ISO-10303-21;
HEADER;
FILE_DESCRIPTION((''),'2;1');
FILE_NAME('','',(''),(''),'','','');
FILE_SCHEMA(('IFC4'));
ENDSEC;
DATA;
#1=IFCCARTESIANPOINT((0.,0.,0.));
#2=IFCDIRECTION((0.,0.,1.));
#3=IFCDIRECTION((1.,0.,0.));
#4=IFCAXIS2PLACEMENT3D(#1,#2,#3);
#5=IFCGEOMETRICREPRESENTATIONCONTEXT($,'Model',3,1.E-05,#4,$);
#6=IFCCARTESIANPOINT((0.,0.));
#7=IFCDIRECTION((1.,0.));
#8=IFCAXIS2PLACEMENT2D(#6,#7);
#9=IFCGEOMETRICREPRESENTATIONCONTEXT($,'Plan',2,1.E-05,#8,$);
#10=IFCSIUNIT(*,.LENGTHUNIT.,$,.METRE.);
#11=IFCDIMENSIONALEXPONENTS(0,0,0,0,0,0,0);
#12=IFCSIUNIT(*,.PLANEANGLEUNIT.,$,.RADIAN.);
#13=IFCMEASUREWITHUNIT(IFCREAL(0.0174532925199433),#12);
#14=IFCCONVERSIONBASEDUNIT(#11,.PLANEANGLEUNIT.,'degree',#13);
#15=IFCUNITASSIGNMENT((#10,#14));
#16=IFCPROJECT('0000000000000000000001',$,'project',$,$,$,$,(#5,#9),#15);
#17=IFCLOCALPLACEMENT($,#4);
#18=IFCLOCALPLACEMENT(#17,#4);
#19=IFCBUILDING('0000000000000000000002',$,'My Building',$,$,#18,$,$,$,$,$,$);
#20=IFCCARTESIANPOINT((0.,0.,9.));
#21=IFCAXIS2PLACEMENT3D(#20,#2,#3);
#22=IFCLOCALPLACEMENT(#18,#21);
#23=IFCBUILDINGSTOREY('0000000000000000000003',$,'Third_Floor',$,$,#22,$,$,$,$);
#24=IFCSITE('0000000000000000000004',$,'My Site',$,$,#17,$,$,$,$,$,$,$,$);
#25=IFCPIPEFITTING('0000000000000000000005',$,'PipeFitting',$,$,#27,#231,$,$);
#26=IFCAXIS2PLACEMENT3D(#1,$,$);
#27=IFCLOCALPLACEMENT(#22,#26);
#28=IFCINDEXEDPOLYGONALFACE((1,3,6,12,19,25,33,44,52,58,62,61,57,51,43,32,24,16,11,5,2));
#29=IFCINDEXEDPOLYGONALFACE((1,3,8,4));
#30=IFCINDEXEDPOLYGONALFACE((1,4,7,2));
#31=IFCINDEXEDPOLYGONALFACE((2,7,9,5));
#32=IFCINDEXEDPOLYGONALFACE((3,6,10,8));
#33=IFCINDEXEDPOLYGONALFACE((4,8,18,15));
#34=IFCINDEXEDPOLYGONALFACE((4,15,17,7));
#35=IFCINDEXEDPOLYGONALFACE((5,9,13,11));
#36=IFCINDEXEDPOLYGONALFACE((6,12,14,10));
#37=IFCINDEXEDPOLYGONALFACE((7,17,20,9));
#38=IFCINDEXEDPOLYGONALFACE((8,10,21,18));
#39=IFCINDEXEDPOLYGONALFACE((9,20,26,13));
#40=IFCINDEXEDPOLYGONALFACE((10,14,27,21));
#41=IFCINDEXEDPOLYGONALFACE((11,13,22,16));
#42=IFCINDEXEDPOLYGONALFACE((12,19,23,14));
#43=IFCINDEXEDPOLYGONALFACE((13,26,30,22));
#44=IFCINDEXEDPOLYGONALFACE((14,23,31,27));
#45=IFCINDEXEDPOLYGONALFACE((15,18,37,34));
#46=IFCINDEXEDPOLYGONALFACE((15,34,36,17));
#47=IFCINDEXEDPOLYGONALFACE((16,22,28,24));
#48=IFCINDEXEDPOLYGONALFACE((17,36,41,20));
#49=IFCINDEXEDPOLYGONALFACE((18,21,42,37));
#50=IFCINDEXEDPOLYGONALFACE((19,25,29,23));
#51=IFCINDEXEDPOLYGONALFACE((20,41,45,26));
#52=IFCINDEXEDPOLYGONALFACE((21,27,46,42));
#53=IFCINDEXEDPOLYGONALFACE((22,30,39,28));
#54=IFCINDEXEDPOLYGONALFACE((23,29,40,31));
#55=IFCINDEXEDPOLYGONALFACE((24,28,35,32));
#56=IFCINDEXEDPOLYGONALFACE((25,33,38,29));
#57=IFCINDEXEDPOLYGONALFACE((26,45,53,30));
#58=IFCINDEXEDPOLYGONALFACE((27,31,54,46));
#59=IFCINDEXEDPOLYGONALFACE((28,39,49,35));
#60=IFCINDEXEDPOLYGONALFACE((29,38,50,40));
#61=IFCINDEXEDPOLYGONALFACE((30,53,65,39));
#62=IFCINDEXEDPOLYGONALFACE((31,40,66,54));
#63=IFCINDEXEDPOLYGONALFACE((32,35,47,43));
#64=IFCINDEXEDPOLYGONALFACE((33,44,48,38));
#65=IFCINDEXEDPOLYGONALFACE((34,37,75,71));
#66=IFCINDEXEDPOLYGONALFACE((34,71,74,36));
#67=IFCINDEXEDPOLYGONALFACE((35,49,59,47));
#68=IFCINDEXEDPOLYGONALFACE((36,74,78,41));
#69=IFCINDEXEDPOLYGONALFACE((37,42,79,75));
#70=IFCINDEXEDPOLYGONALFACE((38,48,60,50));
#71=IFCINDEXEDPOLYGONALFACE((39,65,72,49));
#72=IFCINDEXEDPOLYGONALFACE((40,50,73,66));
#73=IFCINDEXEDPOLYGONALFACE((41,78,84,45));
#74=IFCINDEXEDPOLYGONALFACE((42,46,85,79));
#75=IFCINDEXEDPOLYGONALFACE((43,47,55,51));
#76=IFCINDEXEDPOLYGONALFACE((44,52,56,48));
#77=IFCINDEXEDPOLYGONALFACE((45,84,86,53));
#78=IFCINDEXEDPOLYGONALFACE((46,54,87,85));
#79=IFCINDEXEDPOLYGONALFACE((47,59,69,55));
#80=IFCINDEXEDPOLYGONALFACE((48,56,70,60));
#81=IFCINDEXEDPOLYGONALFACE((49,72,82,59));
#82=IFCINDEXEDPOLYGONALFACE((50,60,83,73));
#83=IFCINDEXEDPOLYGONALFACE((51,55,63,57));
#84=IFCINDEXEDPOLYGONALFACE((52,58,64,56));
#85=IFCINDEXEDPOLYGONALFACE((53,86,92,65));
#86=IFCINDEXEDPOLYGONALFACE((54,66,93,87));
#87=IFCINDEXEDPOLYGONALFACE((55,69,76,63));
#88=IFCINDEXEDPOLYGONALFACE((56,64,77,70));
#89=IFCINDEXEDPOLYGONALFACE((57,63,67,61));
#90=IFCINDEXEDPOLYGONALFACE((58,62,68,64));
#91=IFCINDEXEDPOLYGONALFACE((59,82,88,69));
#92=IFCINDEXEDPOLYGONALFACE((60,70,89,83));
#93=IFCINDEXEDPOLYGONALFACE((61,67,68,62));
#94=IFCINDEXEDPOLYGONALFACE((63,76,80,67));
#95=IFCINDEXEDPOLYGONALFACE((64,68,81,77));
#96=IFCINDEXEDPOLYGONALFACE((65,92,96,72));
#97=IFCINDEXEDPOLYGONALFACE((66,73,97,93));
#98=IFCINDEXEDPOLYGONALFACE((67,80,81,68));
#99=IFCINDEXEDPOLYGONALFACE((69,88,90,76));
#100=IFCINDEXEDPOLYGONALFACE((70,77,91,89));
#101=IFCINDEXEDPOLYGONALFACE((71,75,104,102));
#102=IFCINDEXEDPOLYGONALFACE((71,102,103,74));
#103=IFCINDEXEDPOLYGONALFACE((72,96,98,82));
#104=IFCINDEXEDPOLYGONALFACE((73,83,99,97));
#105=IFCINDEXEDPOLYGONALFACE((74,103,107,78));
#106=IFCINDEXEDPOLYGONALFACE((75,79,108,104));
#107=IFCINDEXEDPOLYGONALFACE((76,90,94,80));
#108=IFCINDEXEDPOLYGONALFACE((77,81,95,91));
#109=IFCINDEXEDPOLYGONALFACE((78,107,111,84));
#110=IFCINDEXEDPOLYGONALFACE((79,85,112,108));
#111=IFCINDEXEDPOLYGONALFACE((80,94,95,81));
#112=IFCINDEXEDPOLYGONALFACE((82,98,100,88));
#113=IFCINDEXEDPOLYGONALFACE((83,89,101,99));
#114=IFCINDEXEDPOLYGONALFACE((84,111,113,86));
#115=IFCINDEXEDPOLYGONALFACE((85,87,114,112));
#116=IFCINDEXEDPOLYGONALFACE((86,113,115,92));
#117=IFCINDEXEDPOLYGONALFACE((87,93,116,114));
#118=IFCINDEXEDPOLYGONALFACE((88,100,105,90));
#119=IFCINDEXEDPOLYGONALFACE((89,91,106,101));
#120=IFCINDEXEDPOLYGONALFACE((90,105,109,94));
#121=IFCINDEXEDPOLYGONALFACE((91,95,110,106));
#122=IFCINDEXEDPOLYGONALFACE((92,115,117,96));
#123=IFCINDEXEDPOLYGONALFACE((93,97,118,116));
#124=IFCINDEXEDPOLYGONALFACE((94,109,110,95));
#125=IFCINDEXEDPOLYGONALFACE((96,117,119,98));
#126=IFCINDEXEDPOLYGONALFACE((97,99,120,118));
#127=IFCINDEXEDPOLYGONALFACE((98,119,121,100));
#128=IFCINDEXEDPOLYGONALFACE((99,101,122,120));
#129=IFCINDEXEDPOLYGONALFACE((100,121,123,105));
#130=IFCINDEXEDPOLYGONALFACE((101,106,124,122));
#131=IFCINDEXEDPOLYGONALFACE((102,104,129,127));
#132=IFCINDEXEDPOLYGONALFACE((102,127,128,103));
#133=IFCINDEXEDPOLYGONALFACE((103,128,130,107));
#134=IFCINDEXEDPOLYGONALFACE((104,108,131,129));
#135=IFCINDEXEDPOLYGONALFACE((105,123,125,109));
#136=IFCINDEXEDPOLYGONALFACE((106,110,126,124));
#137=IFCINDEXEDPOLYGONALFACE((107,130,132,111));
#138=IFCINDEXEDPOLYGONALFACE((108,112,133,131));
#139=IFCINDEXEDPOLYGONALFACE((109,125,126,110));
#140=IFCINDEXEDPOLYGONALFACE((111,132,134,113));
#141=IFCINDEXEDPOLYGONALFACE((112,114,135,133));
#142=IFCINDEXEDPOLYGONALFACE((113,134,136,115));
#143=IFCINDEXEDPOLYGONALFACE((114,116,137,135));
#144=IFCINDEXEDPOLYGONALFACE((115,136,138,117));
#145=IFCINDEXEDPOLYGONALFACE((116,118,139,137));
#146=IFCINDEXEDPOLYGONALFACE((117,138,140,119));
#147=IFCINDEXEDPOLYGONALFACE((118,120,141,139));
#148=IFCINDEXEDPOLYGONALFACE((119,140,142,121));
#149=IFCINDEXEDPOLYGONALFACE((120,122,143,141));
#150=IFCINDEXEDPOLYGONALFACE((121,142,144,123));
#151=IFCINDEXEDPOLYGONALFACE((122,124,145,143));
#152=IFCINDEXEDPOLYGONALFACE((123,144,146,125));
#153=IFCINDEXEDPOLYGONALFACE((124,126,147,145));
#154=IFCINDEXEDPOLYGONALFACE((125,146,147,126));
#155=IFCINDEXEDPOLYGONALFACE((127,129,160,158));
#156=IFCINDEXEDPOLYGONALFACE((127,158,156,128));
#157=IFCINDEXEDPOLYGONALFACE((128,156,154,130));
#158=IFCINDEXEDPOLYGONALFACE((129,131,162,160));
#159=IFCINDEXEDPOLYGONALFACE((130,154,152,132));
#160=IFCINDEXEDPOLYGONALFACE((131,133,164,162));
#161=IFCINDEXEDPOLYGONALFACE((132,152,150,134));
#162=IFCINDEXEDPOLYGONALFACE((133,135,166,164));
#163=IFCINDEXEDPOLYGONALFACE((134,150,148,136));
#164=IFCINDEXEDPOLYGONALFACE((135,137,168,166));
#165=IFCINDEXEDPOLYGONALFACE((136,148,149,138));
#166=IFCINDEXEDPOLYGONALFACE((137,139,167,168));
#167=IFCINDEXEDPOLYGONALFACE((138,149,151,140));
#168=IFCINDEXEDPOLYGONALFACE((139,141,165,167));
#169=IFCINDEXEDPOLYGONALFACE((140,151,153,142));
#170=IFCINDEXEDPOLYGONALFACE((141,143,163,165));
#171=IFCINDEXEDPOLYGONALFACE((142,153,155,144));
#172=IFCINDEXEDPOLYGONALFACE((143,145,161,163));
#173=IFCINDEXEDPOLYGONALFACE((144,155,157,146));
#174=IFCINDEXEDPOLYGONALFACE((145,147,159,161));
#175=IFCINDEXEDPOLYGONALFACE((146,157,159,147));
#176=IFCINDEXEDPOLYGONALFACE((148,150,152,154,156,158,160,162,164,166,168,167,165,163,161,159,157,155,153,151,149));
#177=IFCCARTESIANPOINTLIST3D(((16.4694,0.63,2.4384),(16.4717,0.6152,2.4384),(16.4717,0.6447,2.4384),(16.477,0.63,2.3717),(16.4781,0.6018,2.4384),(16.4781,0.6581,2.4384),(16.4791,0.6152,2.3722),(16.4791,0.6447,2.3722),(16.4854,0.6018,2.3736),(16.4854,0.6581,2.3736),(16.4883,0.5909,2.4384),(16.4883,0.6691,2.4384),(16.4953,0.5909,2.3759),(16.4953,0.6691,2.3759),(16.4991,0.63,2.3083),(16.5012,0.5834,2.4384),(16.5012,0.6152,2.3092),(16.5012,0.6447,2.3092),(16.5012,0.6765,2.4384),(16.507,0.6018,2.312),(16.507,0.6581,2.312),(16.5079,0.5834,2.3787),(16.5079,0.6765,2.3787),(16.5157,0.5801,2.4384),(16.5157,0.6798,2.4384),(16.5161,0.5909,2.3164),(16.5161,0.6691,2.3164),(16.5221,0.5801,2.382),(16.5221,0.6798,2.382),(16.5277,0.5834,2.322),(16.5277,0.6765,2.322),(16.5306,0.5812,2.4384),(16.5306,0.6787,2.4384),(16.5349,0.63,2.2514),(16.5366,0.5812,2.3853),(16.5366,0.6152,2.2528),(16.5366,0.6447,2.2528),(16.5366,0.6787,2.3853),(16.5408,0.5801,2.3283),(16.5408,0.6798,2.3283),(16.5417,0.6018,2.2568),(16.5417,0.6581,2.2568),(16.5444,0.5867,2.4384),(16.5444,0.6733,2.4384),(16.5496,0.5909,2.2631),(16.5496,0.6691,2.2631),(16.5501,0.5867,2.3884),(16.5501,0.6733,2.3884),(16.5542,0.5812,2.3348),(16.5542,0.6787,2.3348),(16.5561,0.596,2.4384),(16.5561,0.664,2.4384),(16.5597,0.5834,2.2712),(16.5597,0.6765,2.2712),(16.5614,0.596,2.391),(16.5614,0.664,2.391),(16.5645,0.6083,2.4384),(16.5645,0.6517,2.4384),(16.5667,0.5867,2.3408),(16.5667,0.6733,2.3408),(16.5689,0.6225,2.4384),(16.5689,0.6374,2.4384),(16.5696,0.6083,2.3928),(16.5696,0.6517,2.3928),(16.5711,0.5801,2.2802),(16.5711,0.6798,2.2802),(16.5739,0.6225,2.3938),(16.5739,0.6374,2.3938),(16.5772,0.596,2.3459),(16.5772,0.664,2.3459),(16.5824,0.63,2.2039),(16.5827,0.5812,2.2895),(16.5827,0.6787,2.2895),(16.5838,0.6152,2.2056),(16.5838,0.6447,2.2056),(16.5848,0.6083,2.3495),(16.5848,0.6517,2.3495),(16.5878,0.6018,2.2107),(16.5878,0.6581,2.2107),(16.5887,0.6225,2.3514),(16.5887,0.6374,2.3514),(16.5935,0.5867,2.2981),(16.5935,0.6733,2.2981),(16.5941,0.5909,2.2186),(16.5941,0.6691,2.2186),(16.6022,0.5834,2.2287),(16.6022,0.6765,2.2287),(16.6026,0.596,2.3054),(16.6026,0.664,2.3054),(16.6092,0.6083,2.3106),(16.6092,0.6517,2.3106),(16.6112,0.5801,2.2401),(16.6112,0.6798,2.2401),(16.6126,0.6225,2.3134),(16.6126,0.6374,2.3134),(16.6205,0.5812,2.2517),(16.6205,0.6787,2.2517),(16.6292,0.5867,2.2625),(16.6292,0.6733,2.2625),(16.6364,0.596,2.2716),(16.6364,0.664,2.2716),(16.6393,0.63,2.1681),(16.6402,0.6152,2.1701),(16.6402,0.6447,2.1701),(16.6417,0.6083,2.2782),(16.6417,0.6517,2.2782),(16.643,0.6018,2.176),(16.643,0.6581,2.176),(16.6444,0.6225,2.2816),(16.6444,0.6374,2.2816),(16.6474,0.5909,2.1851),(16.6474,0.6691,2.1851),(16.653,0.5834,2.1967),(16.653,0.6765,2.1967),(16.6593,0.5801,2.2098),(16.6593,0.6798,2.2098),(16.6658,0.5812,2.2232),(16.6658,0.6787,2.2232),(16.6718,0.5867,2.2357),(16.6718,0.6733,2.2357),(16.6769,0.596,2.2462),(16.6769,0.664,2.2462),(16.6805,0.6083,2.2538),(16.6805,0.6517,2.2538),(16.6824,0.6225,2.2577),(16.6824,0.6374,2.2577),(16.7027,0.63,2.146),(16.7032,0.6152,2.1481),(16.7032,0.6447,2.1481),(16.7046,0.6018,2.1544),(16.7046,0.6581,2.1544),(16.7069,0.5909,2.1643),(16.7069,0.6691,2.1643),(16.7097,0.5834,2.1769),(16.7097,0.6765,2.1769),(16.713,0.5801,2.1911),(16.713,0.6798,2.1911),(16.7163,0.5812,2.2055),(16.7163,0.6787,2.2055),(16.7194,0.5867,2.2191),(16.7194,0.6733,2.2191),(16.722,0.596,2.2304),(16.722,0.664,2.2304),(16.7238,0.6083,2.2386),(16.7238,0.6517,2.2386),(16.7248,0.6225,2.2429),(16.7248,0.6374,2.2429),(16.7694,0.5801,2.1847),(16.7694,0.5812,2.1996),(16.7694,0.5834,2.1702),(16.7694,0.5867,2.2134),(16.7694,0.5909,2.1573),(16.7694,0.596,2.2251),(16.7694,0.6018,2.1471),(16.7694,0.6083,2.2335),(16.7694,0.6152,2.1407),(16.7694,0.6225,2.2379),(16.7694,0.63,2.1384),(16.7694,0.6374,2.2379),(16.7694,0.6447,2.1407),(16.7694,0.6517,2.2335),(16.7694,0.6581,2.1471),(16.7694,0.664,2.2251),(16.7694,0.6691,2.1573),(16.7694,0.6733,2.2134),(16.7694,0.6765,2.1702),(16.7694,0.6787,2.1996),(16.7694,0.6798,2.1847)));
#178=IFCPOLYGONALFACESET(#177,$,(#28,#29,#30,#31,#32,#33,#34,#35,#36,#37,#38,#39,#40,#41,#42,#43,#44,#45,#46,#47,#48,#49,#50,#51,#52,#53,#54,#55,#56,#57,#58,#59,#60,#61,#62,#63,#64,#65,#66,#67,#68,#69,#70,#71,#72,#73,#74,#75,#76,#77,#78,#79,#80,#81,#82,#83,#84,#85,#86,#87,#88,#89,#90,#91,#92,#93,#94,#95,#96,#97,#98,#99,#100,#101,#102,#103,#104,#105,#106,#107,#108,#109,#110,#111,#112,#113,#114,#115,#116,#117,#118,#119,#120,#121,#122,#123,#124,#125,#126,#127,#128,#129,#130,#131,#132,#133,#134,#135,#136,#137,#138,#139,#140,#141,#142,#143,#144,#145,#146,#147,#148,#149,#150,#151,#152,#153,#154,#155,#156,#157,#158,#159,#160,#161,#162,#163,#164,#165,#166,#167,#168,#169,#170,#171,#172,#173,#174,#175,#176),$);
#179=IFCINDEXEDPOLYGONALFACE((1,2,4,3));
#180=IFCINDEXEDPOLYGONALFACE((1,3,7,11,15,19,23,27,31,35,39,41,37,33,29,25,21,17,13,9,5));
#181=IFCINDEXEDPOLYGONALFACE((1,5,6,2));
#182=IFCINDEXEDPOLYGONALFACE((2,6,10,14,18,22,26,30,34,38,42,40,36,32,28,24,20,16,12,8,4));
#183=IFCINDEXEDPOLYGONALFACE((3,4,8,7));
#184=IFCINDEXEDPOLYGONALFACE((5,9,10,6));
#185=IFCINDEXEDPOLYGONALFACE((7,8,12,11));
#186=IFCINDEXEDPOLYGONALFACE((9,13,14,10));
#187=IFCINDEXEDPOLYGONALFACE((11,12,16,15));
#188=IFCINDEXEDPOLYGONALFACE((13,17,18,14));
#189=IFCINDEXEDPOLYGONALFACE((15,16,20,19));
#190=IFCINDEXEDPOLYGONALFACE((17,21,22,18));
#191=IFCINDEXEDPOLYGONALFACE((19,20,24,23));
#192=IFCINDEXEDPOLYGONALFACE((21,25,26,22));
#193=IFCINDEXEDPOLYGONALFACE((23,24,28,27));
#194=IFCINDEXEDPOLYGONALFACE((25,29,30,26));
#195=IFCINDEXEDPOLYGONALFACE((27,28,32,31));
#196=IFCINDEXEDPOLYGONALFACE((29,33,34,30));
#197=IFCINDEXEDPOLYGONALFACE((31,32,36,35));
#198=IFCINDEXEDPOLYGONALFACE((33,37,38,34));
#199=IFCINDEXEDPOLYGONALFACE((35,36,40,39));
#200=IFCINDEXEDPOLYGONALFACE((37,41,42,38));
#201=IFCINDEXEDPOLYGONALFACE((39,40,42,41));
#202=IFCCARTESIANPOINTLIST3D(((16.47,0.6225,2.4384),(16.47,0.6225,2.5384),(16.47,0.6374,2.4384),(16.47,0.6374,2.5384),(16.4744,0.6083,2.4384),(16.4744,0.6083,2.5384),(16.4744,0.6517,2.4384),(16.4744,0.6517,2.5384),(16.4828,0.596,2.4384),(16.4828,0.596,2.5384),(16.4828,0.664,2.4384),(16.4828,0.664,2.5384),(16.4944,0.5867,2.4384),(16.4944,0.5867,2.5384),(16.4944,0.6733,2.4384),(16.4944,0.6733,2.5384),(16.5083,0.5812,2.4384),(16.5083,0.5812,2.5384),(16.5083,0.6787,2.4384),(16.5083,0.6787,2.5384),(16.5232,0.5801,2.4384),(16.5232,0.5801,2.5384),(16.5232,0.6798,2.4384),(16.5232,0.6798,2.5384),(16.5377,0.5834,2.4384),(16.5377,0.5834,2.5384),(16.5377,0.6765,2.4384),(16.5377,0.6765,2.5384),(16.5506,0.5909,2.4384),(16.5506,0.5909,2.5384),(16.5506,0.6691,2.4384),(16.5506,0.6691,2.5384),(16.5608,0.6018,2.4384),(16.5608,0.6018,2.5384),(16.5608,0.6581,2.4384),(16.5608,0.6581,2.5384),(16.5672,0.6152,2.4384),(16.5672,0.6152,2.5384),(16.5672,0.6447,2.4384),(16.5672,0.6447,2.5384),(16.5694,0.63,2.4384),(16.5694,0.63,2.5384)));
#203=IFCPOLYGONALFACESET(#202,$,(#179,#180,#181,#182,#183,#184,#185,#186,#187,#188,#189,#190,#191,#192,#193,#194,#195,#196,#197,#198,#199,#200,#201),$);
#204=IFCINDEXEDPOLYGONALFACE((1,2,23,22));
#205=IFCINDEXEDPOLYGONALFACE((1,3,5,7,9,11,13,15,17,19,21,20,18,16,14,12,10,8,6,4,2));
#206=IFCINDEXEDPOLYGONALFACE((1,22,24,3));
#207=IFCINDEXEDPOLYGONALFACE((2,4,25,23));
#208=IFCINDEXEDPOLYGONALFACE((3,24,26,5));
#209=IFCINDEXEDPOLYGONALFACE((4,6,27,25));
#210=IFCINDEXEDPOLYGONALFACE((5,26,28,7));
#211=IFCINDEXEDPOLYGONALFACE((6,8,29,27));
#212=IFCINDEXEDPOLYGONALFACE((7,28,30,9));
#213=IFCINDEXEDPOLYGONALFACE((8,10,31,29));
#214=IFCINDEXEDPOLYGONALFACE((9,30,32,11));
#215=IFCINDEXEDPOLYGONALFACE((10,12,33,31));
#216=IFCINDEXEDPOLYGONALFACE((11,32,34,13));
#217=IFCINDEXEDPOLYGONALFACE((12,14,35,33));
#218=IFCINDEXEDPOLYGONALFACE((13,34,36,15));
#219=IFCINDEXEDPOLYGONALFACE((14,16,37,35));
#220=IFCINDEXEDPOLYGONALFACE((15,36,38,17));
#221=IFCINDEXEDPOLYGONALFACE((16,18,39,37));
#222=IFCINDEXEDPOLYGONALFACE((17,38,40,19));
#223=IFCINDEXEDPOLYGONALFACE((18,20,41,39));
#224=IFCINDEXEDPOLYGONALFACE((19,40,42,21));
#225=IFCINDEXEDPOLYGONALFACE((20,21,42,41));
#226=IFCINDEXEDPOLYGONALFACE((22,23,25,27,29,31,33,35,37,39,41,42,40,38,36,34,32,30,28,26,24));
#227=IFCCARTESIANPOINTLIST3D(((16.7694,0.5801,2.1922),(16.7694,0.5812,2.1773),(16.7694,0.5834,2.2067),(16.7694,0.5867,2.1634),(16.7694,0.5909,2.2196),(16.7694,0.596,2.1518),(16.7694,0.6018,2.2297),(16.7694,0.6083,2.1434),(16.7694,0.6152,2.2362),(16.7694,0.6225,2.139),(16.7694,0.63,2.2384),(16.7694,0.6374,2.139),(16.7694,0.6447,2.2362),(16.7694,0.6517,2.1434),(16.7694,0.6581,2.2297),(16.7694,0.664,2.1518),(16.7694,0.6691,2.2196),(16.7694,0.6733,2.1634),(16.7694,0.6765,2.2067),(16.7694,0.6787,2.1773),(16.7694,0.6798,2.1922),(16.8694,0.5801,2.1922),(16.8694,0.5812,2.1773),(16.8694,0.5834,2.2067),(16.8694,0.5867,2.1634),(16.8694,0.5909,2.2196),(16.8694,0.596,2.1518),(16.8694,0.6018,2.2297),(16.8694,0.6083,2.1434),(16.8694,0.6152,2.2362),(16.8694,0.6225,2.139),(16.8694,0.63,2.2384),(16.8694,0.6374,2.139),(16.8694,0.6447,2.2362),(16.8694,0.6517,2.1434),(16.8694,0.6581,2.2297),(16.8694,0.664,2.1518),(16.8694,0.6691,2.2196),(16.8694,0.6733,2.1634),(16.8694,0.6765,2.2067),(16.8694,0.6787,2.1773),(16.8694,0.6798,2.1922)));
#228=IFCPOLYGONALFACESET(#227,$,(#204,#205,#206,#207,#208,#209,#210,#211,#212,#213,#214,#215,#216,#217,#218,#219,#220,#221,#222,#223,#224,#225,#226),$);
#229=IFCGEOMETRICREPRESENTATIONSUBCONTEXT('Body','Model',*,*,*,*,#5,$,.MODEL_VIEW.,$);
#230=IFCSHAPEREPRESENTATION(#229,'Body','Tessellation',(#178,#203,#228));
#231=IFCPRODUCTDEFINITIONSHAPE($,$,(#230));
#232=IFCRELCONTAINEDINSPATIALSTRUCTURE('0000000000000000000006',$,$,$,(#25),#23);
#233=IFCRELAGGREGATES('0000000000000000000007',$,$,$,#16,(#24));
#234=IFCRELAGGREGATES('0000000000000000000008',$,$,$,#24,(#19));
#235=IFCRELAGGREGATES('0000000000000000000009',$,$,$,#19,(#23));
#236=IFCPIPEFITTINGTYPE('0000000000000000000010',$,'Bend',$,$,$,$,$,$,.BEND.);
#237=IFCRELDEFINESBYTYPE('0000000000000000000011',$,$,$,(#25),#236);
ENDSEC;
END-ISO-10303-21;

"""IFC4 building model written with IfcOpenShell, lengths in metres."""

from ifc_helpers import new_model, entity, si_unit, converted_unit, frame, origin_with_axes, origin_2d_with_axis, place, context, subcontext, project, spatial, circle, extrude, source, transform, mapped, type_object, type_shapes, element, save


model = new_model("IFC4")

# Units and contexts
model_context = context("Model", 3, precision=1e-05, world=origin_with_axes())
plan_context = context("Plan", 2, precision=1e-05, world=origin_2d_with_axis())
body_context = subcontext(model_context, "Body", "Model", "MODEL_VIEW")
ifc_project = project(units=[si_unit("LENGTHUNIT", "METRE"), converted_unit("PLANEANGLEUNIT", "degree", entity("IfcReal", 0.0174532925199433), si_unit("PLANEANGLEUNIT", "RADIAN"), dimensions=[0, 0, 0, 0, 0, 0, 0])], contexts=[model_context, plan_context])

# Site, building, storey
site_placement = place(None, origin_with_axes())
site = spatial("IfcSite", under=ifc_project, at=site_placement, Name="My Site")
building_placement = place(site_placement, origin_with_axes())
building = spatial("IfcBuilding", under=site, at=building_placement, Name="My Building")
storey_placement = place(building_placement, frame((0.0, 0.0, 9.0), z_axis=(0.0, 0.0, 1.0), x_axis=(1.0, 0.0, 0.0)))
storey = spatial("IfcBuildingStorey", under=building, at=storey_placement, Name="Third_Floor")

# Pipe fitting
pipe_fitting_type = type_object("IfcPipeFittingType", Name="Bend", PredefinedType="BEND")
shared_shape = source(origin_with_axes(), body_context, "Body", "SolidModel", [
    entity("IfcSweptDiskSolid", entity("IfcIndexedPolyCurve", entity("IfcCartesianPointList3D", [[0.0, 0.0, -0.1], [0.0732, 0.0, -0.2768], [0.25, 0.0, -0.35]]), [entity("IfcArcIndex", [1, 2, 3])]), 0.05),
    extrude(circle(Radius=0.05), origin_with_axes(), (0.0, 0.0, -1.0), 0.1),
    extrude(circle(Radius=0.05), frame((0.25, 0.0, -0.35), z_axis=(1.0, 0.0, 0.0), x_axis=(0.0, 0.0, 1.0)), (0.0, 0.0, 1.0), 0.1),
])
type_shapes(pipe_fitting_type, [shared_shape])
for number, where, z_axis, x_axis, name in (
    (1, (16.5194, 0.63, 2.5384), (0.0, 0.0, 1.0), (1.0, 0.0, 0.0), "PipeFitting"),
):
    element("IfcPipeFitting", number, at=place(storey_placement, frame(where, z_axis=z_axis, x_axis=x_axis)), inside=storey, type_object=pipe_fitting_type, Name=name, context=body_context, shape_type="MappedRepresentation", body=[
        mapped(shared_shape, transform((0.0, 0.0, 0.0), x_axis=(1.0, 0.0, 0.0), y_axis=(0.0, 1.0, 0.0), z_axis=(0.0, 0.0, 1.0), scale=1.0)),
    ])

save(model, "model.ifc")
